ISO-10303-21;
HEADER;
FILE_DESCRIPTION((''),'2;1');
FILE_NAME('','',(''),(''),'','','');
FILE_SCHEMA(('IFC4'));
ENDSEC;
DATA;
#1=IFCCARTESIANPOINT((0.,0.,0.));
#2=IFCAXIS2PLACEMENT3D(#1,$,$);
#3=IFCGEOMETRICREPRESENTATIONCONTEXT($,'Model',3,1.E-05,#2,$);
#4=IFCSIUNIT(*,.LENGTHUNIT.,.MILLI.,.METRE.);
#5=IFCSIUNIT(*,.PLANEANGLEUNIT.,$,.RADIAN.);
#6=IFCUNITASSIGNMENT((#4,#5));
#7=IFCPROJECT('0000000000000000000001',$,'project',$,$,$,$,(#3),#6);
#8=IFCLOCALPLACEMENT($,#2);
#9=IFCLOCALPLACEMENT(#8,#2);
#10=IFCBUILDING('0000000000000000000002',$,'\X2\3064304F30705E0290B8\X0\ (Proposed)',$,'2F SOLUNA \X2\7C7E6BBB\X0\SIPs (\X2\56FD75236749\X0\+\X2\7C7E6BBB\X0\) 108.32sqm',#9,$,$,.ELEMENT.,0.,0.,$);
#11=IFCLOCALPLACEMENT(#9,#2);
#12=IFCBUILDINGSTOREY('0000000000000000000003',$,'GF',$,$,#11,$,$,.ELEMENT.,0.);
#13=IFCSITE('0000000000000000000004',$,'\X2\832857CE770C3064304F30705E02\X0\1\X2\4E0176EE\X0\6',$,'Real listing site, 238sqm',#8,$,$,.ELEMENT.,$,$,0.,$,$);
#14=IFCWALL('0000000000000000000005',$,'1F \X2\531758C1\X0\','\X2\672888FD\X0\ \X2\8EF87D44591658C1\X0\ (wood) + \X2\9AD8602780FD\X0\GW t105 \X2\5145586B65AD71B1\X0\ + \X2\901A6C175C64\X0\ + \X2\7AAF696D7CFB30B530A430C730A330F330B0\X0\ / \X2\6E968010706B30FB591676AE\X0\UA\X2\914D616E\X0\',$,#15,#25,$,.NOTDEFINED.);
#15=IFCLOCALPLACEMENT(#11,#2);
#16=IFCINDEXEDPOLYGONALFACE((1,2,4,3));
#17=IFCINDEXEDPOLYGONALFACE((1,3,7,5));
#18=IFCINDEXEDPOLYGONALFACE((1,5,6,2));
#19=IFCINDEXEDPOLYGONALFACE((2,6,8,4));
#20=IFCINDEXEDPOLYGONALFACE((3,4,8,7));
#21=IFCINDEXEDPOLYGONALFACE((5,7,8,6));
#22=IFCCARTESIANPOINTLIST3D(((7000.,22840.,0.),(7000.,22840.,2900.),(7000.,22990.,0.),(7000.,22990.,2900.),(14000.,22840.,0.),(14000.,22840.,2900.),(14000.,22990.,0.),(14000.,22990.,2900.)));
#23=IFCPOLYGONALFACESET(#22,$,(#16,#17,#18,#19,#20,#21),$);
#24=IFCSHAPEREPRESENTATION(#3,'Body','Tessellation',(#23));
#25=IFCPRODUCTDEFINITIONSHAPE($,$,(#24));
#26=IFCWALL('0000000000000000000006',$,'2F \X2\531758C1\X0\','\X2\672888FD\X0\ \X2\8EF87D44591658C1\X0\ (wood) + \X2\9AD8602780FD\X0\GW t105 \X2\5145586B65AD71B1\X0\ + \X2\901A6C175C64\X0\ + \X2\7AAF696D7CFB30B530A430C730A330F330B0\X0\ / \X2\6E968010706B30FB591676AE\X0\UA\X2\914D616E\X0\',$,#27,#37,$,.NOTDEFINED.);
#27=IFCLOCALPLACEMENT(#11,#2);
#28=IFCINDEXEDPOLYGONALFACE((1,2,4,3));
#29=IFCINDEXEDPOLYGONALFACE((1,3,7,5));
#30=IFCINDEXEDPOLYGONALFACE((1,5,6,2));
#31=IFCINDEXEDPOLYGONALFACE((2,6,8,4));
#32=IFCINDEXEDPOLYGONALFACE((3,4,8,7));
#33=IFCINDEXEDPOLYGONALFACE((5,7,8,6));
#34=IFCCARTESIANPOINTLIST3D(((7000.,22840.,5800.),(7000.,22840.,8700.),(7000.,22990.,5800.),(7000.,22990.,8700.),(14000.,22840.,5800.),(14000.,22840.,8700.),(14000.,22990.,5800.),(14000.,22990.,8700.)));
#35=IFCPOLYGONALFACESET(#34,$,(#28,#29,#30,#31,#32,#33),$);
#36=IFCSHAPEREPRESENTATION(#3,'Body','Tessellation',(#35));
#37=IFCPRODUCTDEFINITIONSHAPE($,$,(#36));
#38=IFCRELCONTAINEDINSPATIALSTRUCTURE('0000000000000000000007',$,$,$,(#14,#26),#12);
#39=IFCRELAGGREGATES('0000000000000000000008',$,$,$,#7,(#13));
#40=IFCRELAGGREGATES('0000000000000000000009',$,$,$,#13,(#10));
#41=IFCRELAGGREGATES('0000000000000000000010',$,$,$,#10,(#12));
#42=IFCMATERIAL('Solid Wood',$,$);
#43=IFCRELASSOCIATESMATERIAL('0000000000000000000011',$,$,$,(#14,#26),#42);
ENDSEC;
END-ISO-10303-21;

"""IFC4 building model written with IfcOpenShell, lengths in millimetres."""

from ifc_helpers import new_model, si_unit, frame, frame_2d, origin, place, context, project, spatial, rectangle, extrude, material, element, save


model = new_model("IFC4")

# Units and contexts
model_context = context("Model", 3, precision=1e-05, world=origin())
ifc_project = project(units=[si_unit("LENGTHUNIT", "METRE", prefix="MILLI"), si_unit("PLANEANGLEUNIT", "RADIAN")], contexts=[model_context])

# Site, building, storey
site_placement = place(None, origin())
site = spatial("IfcSite", under=ifc_project, at=site_placement, Name="茨城県つくば市1丁目6", ObjectType="Real listing site, 238sqm", CompositionType="ELEMENT", RefElevation=0.0)
building_placement = place(site_placement, origin())
building = spatial("IfcBuilding", under=site, at=building_placement, Name="つくば市邸 (Proposed)", ObjectType="2F SOLUNA 籾殻SIPs (国産杉+籾殻) 108.32sqm", CompositionType="ELEMENT", ElevationOfRefHeight=0.0, ElevationOfTerrain=0.0)
storey_placement = place(building_placement, origin())
storey = spatial("IfcBuildingStorey", under=building, at=storey_placement, Name="GF", CompositionType="ELEMENT", Elevation=0.0)

# Shared definitions
ifc_material_1 = material(Name="Solid Wood")

# Wall
wall_1_placement = place(storey_placement, frame((3500.0, 11420.0, 0.0)))
element("IfcWall", 1, at=wall_1_placement, inside=storey, material=ifc_material_1, Name="1F 北壁", Description="木製 軸組外壁 (wood) + 高性能GW t105 充填断熱 + 通気層 + 窯業系サイディング / 準耐火・外皮UA配慮", PredefinedType="NOTDEFINED", context=model_context, shape_type="SweptSolid", body=[
    extrude(rectangle(XDim=7000.0, YDim=150.0, at=frame_2d((3500.0, 75.0))), frame((3500.0, 11420.0, 0.0)), (0.0, 0.0, 1.0), 2900.0),
])

# Wall
wall_2_placement = place(storey_placement, frame((3500.0, 11420.0, 2900.0)))
element("IfcWall", 2, at=wall_2_placement, inside=storey, material=ifc_material_1, Name="2F 北壁", Description="木製 軸組外壁 (wood) + 高性能GW t105 充填断熱 + 通気層 + 窯業系サイディング / 準耐火・外皮UA配慮", PredefinedType="NOTDEFINED", context=model_context, shape_type="SweptSolid", body=[
    extrude(rectangle(XDim=7000.0, YDim=150.0, at=frame_2d((3500.0, 75.0))), frame((3500.0, 11420.0, 2900.0)), (0.0, 0.0, 1.0), 2900.0),
])

save(model, "model.ifc")
